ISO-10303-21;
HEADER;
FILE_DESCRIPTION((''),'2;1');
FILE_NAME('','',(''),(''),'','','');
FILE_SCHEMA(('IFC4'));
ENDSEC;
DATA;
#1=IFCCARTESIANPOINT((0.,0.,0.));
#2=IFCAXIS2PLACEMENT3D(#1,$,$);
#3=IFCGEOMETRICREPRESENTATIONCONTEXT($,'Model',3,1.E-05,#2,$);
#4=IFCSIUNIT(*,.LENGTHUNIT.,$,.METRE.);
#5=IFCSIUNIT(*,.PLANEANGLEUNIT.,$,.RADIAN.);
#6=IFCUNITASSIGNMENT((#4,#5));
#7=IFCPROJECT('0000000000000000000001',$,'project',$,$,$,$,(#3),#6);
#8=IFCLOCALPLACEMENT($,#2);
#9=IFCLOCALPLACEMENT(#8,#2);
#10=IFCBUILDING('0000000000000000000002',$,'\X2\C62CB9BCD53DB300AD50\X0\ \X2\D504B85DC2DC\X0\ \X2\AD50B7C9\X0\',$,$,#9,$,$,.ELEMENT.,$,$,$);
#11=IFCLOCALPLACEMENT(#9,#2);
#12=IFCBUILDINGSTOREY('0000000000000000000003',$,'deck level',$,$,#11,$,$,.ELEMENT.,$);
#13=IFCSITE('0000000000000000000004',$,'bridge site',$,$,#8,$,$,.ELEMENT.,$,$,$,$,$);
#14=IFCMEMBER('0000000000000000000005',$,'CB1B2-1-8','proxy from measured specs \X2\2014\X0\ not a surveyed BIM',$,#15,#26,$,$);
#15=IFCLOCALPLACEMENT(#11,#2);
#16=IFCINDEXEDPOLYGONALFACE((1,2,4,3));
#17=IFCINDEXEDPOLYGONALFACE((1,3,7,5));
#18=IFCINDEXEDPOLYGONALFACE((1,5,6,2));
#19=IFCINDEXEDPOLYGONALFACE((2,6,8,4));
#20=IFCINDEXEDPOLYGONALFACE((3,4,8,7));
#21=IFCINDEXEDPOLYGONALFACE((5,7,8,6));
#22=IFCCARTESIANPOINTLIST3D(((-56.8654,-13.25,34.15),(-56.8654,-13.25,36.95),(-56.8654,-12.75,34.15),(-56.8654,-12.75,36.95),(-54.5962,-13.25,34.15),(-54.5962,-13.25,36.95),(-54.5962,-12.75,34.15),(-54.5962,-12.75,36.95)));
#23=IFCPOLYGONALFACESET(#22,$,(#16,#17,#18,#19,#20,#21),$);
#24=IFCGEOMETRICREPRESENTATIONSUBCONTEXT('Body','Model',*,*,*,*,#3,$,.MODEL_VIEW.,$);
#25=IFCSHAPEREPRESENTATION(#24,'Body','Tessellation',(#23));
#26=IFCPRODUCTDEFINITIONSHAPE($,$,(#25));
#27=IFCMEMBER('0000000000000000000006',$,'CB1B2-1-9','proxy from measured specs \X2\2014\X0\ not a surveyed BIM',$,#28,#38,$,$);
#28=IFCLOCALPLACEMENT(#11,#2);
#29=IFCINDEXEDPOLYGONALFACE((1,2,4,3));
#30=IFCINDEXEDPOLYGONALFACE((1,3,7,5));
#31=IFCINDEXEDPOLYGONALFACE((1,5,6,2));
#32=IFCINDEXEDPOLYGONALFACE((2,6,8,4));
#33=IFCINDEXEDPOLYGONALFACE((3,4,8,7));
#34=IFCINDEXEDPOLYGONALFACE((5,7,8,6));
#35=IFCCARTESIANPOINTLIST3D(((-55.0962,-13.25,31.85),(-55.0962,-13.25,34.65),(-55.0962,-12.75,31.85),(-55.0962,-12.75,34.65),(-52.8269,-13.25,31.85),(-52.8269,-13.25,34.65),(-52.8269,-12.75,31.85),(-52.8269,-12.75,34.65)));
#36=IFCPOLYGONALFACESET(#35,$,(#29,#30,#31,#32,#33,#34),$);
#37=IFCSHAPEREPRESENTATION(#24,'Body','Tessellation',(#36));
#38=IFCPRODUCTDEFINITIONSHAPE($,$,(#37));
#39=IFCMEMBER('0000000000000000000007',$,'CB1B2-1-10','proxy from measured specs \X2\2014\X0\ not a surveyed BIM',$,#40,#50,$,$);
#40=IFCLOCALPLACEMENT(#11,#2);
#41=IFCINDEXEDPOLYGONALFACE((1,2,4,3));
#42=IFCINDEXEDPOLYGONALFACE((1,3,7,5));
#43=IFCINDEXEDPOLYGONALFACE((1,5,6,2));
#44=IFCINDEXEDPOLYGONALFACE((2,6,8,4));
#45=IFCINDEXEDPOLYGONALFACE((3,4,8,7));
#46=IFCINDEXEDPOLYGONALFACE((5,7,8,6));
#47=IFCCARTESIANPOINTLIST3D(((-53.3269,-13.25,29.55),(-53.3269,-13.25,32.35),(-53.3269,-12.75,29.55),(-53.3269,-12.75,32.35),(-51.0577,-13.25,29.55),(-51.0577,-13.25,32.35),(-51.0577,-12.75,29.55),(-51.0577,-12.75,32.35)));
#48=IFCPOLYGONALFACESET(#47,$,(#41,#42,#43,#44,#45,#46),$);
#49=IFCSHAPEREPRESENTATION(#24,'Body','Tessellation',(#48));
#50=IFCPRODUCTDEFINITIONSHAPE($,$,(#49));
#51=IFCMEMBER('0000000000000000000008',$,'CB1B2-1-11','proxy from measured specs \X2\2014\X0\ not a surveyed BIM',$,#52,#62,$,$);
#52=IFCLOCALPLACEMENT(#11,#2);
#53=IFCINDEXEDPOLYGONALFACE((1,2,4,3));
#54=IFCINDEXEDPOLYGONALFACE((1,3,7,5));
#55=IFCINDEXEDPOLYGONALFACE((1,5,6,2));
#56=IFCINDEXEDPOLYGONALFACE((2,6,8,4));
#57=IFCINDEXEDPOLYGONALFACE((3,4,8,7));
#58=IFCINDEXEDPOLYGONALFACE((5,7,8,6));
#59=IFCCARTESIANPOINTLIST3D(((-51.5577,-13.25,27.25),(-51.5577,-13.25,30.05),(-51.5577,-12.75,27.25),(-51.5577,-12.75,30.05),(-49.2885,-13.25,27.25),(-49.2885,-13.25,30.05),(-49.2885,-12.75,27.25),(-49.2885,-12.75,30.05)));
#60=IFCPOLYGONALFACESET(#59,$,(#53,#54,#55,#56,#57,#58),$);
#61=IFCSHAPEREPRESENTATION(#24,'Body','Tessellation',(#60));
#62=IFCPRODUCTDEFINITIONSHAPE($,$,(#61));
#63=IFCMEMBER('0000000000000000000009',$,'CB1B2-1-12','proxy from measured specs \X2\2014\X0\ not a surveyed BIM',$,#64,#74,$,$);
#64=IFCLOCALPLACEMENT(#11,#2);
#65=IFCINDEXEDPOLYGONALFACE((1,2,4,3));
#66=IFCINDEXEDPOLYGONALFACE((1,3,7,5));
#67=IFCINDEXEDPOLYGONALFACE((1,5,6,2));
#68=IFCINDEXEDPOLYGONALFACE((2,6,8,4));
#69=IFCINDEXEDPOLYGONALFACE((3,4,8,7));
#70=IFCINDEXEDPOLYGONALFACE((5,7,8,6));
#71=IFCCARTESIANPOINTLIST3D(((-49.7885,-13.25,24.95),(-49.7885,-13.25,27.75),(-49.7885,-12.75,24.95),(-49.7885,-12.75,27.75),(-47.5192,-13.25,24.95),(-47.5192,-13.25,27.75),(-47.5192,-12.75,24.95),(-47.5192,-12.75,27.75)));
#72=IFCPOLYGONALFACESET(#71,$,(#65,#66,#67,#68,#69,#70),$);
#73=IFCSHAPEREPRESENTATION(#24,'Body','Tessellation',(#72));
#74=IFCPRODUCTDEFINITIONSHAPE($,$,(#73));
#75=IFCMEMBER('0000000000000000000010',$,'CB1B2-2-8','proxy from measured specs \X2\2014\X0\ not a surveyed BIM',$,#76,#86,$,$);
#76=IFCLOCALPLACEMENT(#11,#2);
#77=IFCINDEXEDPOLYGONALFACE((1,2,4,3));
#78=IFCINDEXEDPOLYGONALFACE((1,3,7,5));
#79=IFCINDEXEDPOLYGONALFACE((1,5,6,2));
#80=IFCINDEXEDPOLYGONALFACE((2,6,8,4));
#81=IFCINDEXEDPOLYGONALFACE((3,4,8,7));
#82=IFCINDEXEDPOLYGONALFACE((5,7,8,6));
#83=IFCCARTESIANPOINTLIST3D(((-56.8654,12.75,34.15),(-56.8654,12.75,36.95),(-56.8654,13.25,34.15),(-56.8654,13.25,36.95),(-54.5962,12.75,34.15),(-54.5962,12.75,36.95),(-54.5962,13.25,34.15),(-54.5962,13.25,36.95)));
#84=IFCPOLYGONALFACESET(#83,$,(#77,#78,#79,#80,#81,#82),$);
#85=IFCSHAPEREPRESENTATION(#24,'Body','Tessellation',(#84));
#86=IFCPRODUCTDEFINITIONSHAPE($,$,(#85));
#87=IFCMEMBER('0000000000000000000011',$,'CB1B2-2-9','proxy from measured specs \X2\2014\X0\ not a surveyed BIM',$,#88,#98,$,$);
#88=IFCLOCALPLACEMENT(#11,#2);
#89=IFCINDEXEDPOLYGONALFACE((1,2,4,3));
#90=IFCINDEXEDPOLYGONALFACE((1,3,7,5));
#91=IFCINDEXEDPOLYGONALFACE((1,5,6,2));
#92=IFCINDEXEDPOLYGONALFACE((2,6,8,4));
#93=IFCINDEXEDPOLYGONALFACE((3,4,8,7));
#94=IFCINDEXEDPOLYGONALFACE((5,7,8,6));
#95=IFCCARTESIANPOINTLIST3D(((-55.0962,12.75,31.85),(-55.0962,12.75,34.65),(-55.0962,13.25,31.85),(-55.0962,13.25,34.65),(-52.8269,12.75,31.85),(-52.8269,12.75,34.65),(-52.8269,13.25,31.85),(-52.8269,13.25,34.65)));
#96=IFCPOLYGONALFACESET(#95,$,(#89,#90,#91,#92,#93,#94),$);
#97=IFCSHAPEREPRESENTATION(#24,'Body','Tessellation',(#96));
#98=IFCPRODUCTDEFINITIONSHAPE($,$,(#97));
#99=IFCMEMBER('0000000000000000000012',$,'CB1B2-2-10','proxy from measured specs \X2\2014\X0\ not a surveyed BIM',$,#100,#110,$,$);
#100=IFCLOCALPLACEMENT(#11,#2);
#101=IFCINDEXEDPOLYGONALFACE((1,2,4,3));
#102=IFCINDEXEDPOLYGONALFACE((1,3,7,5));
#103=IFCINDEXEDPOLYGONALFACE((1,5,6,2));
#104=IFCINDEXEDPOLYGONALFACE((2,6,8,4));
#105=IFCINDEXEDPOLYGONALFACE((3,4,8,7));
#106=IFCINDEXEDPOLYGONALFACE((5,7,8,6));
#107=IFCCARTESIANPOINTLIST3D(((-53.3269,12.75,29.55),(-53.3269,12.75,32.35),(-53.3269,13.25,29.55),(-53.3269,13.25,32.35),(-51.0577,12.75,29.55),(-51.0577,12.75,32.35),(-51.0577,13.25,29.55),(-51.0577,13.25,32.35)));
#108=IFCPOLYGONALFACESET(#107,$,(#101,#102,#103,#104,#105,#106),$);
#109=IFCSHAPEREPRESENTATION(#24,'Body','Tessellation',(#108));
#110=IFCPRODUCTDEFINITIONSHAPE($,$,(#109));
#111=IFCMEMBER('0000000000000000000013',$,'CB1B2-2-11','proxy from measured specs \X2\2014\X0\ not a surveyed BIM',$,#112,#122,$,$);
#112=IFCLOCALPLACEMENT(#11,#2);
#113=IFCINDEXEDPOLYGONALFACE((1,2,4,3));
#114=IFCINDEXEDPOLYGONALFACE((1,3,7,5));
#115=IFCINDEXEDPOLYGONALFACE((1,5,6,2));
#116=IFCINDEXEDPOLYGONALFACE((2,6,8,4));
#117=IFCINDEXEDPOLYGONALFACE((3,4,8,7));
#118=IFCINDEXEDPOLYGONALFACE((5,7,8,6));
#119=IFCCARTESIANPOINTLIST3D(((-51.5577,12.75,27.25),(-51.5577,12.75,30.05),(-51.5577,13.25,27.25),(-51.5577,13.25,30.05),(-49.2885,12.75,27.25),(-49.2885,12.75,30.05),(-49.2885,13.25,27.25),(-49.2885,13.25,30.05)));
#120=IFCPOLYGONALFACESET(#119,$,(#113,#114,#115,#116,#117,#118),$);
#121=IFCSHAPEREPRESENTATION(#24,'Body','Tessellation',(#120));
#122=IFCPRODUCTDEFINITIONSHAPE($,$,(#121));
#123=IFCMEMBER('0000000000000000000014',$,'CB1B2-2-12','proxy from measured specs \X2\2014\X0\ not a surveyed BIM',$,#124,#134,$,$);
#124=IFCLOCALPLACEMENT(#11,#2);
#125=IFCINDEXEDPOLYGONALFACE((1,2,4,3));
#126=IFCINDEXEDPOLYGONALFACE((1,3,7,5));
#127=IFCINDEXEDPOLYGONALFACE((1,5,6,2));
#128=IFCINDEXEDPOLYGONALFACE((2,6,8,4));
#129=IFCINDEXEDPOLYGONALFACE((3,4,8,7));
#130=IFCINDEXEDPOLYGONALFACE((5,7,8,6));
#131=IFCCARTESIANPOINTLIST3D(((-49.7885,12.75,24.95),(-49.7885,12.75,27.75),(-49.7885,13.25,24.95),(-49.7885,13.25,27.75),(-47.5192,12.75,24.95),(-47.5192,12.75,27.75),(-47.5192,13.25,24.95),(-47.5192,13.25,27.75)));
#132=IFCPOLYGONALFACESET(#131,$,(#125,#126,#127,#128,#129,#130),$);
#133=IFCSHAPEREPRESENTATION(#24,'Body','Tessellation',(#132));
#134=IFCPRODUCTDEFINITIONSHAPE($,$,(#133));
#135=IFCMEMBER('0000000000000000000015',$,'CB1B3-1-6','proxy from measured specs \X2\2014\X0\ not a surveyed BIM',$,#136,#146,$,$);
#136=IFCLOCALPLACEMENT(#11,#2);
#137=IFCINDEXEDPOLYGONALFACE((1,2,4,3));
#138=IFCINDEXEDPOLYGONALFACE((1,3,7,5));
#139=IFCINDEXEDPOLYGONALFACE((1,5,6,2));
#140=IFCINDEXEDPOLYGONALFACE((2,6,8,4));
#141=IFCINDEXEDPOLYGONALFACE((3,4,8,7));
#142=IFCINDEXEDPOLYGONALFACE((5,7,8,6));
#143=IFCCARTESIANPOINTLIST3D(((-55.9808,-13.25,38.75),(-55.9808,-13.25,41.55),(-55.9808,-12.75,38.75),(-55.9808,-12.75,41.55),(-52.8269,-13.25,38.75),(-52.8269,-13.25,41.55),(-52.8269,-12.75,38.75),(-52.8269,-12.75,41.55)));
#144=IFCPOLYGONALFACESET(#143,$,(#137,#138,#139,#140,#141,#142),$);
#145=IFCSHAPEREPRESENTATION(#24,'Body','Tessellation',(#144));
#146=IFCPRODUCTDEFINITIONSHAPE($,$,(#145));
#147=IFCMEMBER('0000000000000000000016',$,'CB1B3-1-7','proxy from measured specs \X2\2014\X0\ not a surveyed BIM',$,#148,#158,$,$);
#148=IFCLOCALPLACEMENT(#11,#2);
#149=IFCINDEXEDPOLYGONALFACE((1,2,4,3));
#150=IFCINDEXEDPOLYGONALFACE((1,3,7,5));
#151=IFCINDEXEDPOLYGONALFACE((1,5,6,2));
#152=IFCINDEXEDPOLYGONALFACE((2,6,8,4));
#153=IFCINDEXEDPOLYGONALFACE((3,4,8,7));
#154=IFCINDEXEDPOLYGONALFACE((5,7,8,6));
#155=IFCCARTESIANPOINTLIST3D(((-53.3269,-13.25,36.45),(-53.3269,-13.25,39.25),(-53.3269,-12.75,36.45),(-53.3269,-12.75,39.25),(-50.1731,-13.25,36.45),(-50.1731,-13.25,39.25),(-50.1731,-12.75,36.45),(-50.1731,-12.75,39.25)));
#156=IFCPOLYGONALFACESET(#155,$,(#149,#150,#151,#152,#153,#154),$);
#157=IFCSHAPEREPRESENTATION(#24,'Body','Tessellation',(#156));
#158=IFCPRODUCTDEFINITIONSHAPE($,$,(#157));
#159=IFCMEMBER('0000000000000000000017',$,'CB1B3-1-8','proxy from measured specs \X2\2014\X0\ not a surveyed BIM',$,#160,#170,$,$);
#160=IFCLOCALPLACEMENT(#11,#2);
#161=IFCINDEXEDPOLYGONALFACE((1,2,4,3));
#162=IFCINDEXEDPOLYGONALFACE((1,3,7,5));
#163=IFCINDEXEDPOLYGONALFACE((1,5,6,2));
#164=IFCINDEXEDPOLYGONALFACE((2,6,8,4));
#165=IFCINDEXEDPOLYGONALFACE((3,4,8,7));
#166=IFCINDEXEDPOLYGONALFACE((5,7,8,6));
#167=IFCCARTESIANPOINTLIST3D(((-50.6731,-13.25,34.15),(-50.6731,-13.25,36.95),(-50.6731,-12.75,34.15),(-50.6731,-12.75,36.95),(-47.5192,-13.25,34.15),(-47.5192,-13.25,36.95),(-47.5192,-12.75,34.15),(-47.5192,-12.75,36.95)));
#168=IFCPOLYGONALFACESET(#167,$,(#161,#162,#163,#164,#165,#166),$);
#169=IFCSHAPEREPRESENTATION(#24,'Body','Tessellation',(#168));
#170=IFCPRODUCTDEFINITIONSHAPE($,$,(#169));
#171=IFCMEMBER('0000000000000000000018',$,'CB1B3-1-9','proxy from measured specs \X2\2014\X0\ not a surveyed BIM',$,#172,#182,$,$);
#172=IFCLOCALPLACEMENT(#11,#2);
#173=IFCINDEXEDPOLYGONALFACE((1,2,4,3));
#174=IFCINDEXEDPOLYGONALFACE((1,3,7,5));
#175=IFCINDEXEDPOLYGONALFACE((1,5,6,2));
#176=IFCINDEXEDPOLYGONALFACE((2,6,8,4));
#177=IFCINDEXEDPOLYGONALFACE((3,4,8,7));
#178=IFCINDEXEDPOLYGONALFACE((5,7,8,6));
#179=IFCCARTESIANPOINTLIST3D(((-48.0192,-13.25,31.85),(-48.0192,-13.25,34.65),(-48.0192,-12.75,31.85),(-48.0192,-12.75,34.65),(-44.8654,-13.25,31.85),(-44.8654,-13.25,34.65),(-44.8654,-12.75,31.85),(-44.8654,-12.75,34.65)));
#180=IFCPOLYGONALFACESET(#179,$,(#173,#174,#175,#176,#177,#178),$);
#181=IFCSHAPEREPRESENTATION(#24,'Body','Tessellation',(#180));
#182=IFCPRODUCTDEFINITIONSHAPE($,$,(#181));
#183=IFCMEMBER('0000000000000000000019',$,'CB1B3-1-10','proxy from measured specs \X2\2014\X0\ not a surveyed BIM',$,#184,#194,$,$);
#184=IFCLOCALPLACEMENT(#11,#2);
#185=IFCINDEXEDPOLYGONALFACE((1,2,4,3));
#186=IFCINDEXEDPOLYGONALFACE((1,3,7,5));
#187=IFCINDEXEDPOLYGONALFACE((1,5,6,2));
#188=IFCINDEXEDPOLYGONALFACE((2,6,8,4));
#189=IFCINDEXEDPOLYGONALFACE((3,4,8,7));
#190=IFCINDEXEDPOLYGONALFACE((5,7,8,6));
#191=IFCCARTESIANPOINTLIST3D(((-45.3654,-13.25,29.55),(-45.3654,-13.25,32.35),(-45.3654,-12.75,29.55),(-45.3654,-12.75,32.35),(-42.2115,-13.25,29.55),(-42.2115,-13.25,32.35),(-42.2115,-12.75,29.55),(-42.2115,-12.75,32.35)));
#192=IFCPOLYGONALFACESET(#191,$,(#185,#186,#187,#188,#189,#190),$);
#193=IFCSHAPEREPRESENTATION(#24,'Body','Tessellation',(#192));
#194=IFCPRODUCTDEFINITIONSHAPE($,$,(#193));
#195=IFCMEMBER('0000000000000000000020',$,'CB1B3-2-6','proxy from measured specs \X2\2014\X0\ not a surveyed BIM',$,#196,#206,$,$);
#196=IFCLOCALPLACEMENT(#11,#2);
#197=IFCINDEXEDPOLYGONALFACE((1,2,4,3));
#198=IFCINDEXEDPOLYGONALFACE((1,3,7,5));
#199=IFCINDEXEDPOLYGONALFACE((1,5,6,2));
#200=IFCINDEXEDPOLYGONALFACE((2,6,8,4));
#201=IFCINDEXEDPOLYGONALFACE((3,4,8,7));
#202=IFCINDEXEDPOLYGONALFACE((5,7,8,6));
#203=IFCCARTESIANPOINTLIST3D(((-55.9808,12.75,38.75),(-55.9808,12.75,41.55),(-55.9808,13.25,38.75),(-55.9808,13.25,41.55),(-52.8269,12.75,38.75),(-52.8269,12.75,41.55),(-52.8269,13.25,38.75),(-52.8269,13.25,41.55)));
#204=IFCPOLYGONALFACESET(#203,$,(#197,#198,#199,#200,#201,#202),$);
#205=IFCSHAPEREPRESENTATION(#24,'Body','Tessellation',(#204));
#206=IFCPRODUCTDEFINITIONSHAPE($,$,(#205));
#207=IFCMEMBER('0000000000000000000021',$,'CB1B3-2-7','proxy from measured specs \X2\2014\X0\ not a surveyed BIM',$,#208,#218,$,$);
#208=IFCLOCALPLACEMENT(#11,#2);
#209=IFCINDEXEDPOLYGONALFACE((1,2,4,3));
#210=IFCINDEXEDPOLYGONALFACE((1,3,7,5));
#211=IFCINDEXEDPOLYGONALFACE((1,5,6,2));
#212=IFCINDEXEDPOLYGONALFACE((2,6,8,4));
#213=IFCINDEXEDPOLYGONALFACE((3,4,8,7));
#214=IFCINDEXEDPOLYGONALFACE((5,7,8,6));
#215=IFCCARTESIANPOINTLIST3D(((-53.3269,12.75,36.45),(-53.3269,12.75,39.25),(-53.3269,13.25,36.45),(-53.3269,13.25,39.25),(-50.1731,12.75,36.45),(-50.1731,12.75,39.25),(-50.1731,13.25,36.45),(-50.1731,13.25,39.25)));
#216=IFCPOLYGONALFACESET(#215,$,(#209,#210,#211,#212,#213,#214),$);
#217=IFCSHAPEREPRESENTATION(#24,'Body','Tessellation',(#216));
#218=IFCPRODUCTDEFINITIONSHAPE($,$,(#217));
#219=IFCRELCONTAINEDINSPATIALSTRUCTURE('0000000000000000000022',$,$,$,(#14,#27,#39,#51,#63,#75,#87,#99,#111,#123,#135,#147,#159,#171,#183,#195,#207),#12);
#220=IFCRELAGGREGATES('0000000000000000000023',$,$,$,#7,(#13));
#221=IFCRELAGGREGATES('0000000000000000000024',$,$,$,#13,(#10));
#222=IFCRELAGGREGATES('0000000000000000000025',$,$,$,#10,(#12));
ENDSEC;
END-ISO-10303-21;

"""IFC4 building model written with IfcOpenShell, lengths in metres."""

from ifc_helpers import new_model, si_unit, frame, origin, origin_2d, place, context, subcontext, project, spatial, rectangle, extrude, element, save


model = new_model("IFC4")

# Units and contexts
model_context = context("Model", 3, precision=1e-05, world=origin())
body_context = subcontext(model_context, "Body", "Model", "MODEL_VIEW")
ifc_project = project(units=[si_unit("LENGTHUNIT", "METRE"), si_unit("PLANEANGLEUNIT", "RADIAN")], contexts=[model_context])

# Site, building, storey
site_placement = place(None, origin())
site = spatial("IfcSite", under=ifc_project, at=site_placement, Name="bridge site", CompositionType="ELEMENT")
building_placement = place(site_placement, origin())
building = spatial("IfcBuilding", under=site, at=building_placement, Name="올림픽대교 프록시 교량", CompositionType="ELEMENT")
storey_placement = place(building_placement, origin())
storey = spatial("IfcBuildingStorey", under=building, at=storey_placement, Name="deck level", CompositionType="ELEMENT")

# Members
member_1_placement = place(storey_placement, frame((-55.7308, -13.0, 34.15)))
element("IfcMember", 1, at=member_1_placement, inside=storey, Name="CB1B2-1-8", Description="proxy from measured specs — not a surveyed BIM", context=body_context, shape_type="SweptSolid", body=[
    extrude(rectangle(XDim=2.2692, YDim=0.5, at=origin_2d()), origin(), (0.0, 0.0, 1.0), 2.8),
])
member_2_placement = place(storey_placement, frame((-53.9615, -13.0, 31.85)))
element("IfcMember", 2, at=member_2_placement, inside=storey, Name="CB1B2-1-9", Description="proxy from measured specs — not a surveyed BIM", context=body_context, shape_type="SweptSolid", body=[
    extrude(rectangle(XDim=2.2692, YDim=0.5, at=origin_2d()), origin(), (0.0, 0.0, 1.0), 2.8),
])
member_3_placement = place(storey_placement, frame((-52.1923, -13.0, 29.55)))
element("IfcMember", 3, at=member_3_placement, inside=storey, Name="CB1B2-1-10", Description="proxy from measured specs — not a surveyed BIM", context=body_context, shape_type="SweptSolid", body=[
    extrude(rectangle(XDim=2.2692, YDim=0.5, at=origin_2d()), origin(), (0.0, 0.0, 1.0), 2.8),
])
member_4_placement = place(storey_placement, frame((-50.4231, -13.0, 27.25)))
element("IfcMember", 4, at=member_4_placement, inside=storey, Name="CB1B2-1-11", Description="proxy from measured specs — not a surveyed BIM", context=body_context, shape_type="SweptSolid", body=[
    extrude(rectangle(XDim=2.2692, YDim=0.5, at=origin_2d()), origin(), (0.0, 0.0, 1.0), 2.8),
])
member_5_placement = place(storey_placement, frame((-48.6538, -13.0, 24.95)))
element("IfcMember", 5, at=member_5_placement, inside=storey, Name="CB1B2-1-12", Description="proxy from measured specs — not a surveyed BIM", context=body_context, shape_type="SweptSolid", body=[
    extrude(rectangle(XDim=2.2692, YDim=0.5, at=origin_2d()), origin(), (0.0, 0.0, 1.0), 2.8),
])
member_6_placement = place(storey_placement, frame((-55.7308, 13.0, 34.15)))
element("IfcMember", 6, at=member_6_placement, inside=storey, Name="CB1B2-2-8", Description="proxy from measured specs — not a surveyed BIM", context=body_context, shape_type="SweptSolid", body=[
    extrude(rectangle(XDim=2.2692, YDim=0.5, at=origin_2d()), origin(), (0.0, 0.0, 1.0), 2.8),
])
member_7_placement = place(storey_placement, frame((-53.9615, 13.0, 31.85)))
element("IfcMember", 7, at=member_7_placement, inside=storey, Name="CB1B2-2-9", Description="proxy from measured specs — not a surveyed BIM", context=body_context, shape_type="SweptSolid", body=[
    extrude(rectangle(XDim=2.2692, YDim=0.5, at=origin_2d()), origin(), (0.0, 0.0, 1.0), 2.8),
])
member_8_placement = place(storey_placement, frame((-52.1923, 13.0, 29.55)))
element("IfcMember", 8, at=member_8_placement, inside=storey, Name="CB1B2-2-10", Description="proxy from measured specs — not a surveyed BIM", context=body_context, shape_type="SweptSolid", body=[
    extrude(rectangle(XDim=2.2692, YDim=0.5, at=origin_2d()), origin(), (0.0, 0.0, 1.0), 2.8),
])
member_9_placement = place(storey_placement, frame((-50.4231, 13.0, 27.25)))
element("IfcMember", 9, at=member_9_placement, inside=storey, Name="CB1B2-2-11", Description="proxy from measured specs — not a surveyed BIM", context=body_context, shape_type="SweptSolid", body=[
    extrude(rectangle(XDim=2.2692, YDim=0.5, at=origin_2d()), origin(), (0.0, 0.0, 1.0), 2.8),
])
member_10_placement = place(storey_placement, frame((-48.6538, 13.0, 24.95)))
element("IfcMember", 10, at=member_10_placement, inside=storey, Name="CB1B2-2-12", Description="proxy from measured specs — not a surveyed BIM", context=body_context, shape_type="SweptSolid", body=[
    extrude(rectangle(XDim=2.2692, YDim=0.5, at=origin_2d()), origin(), (0.0, 0.0, 1.0), 2.8),
])
member_11_placement = place(storey_placement, frame((-54.4038, -13.0, 38.75)))
element("IfcMember", 11, at=member_11_placement, inside=storey, Name="CB1B3-1-6", Description="proxy from measured specs — not a surveyed BIM", context=body_context, shape_type="SweptSolid", body=[
    extrude(rectangle(XDim=3.1538, YDim=0.5, at=origin_2d()), origin(), (0.0, 0.0, 1.0), 2.8),
])
member_12_placement = place(storey_placement, frame((-51.75, -13.0, 36.45)))
element("IfcMember", 12, at=member_12_placement, inside=storey, Name="CB1B3-1-7", Description="proxy from measured specs — not a surveyed BIM", context=body_context, shape_type="SweptSolid", body=[
    extrude(rectangle(XDim=3.1538, YDim=0.5, at=origin_2d()), origin(), (0.0, 0.0, 1.0), 2.8),
])
member_13_placement = place(storey_placement, frame((-49.0962, -13.0, 34.15)))
element("IfcMember", 13, at=member_13_placement, inside=storey, Name="CB1B3-1-8", Description="proxy from measured specs — not a surveyed BIM", context=body_context, shape_type="SweptSolid", body=[
    extrude(rectangle(XDim=3.1538, YDim=0.5, at=origin_2d()), origin(), (0.0, 0.0, 1.0), 2.8),
])
member_14_placement = place(storey_placement, frame((-46.4423, -13.0, 31.85)))
element("IfcMember", 14, at=member_14_placement, inside=storey, Name="CB1B3-1-9", Description="proxy from measured specs — not a surveyed BIM", context=body_context, shape_type="SweptSolid", body=[
    extrude(rectangle(XDim=3.1538, YDim=0.5, at=origin_2d()), origin(), (0.0, 0.0, 1.0), 2.8),
])
member_15_placement = place(storey_placement, frame((-43.7885, -13.0, 29.55)))
element("IfcMember", 15, at=member_15_placement, inside=storey, Name="CB1B3-1-10", Description="proxy from measured specs — not a surveyed BIM", context=body_context, shape_type="SweptSolid", body=[
    extrude(rectangle(XDim=3.1538, YDim=0.5, at=origin_2d()), origin(), (0.0, 0.0, 1.0), 2.8),
])
member_16_placement = place(storey_placement, frame((-54.4038, 13.0, 38.75)))
element("IfcMember", 16, at=member_16_placement, inside=storey, Name="CB1B3-2-6", Description="proxy from measured specs — not a surveyed BIM", context=body_context, shape_type="SweptSolid", body=[
    extrude(rectangle(XDim=3.1538, YDim=0.5, at=origin_2d()), origin(), (0.0, 0.0, 1.0), 2.8),
])
member_17_placement = place(storey_placement, frame((-51.75, 13.0, 36.45)))
element("IfcMember", 17, at=member_17_placement, inside=storey, Name="CB1B3-2-7", Description="proxy from measured specs — not a surveyed BIM", context=body_context, shape_type="SweptSolid", body=[
    extrude(rectangle(XDim=3.1538, YDim=0.5, at=origin_2d()), origin(), (0.0, 0.0, 1.0), 2.8),
])

save(model, "model.ifc")
